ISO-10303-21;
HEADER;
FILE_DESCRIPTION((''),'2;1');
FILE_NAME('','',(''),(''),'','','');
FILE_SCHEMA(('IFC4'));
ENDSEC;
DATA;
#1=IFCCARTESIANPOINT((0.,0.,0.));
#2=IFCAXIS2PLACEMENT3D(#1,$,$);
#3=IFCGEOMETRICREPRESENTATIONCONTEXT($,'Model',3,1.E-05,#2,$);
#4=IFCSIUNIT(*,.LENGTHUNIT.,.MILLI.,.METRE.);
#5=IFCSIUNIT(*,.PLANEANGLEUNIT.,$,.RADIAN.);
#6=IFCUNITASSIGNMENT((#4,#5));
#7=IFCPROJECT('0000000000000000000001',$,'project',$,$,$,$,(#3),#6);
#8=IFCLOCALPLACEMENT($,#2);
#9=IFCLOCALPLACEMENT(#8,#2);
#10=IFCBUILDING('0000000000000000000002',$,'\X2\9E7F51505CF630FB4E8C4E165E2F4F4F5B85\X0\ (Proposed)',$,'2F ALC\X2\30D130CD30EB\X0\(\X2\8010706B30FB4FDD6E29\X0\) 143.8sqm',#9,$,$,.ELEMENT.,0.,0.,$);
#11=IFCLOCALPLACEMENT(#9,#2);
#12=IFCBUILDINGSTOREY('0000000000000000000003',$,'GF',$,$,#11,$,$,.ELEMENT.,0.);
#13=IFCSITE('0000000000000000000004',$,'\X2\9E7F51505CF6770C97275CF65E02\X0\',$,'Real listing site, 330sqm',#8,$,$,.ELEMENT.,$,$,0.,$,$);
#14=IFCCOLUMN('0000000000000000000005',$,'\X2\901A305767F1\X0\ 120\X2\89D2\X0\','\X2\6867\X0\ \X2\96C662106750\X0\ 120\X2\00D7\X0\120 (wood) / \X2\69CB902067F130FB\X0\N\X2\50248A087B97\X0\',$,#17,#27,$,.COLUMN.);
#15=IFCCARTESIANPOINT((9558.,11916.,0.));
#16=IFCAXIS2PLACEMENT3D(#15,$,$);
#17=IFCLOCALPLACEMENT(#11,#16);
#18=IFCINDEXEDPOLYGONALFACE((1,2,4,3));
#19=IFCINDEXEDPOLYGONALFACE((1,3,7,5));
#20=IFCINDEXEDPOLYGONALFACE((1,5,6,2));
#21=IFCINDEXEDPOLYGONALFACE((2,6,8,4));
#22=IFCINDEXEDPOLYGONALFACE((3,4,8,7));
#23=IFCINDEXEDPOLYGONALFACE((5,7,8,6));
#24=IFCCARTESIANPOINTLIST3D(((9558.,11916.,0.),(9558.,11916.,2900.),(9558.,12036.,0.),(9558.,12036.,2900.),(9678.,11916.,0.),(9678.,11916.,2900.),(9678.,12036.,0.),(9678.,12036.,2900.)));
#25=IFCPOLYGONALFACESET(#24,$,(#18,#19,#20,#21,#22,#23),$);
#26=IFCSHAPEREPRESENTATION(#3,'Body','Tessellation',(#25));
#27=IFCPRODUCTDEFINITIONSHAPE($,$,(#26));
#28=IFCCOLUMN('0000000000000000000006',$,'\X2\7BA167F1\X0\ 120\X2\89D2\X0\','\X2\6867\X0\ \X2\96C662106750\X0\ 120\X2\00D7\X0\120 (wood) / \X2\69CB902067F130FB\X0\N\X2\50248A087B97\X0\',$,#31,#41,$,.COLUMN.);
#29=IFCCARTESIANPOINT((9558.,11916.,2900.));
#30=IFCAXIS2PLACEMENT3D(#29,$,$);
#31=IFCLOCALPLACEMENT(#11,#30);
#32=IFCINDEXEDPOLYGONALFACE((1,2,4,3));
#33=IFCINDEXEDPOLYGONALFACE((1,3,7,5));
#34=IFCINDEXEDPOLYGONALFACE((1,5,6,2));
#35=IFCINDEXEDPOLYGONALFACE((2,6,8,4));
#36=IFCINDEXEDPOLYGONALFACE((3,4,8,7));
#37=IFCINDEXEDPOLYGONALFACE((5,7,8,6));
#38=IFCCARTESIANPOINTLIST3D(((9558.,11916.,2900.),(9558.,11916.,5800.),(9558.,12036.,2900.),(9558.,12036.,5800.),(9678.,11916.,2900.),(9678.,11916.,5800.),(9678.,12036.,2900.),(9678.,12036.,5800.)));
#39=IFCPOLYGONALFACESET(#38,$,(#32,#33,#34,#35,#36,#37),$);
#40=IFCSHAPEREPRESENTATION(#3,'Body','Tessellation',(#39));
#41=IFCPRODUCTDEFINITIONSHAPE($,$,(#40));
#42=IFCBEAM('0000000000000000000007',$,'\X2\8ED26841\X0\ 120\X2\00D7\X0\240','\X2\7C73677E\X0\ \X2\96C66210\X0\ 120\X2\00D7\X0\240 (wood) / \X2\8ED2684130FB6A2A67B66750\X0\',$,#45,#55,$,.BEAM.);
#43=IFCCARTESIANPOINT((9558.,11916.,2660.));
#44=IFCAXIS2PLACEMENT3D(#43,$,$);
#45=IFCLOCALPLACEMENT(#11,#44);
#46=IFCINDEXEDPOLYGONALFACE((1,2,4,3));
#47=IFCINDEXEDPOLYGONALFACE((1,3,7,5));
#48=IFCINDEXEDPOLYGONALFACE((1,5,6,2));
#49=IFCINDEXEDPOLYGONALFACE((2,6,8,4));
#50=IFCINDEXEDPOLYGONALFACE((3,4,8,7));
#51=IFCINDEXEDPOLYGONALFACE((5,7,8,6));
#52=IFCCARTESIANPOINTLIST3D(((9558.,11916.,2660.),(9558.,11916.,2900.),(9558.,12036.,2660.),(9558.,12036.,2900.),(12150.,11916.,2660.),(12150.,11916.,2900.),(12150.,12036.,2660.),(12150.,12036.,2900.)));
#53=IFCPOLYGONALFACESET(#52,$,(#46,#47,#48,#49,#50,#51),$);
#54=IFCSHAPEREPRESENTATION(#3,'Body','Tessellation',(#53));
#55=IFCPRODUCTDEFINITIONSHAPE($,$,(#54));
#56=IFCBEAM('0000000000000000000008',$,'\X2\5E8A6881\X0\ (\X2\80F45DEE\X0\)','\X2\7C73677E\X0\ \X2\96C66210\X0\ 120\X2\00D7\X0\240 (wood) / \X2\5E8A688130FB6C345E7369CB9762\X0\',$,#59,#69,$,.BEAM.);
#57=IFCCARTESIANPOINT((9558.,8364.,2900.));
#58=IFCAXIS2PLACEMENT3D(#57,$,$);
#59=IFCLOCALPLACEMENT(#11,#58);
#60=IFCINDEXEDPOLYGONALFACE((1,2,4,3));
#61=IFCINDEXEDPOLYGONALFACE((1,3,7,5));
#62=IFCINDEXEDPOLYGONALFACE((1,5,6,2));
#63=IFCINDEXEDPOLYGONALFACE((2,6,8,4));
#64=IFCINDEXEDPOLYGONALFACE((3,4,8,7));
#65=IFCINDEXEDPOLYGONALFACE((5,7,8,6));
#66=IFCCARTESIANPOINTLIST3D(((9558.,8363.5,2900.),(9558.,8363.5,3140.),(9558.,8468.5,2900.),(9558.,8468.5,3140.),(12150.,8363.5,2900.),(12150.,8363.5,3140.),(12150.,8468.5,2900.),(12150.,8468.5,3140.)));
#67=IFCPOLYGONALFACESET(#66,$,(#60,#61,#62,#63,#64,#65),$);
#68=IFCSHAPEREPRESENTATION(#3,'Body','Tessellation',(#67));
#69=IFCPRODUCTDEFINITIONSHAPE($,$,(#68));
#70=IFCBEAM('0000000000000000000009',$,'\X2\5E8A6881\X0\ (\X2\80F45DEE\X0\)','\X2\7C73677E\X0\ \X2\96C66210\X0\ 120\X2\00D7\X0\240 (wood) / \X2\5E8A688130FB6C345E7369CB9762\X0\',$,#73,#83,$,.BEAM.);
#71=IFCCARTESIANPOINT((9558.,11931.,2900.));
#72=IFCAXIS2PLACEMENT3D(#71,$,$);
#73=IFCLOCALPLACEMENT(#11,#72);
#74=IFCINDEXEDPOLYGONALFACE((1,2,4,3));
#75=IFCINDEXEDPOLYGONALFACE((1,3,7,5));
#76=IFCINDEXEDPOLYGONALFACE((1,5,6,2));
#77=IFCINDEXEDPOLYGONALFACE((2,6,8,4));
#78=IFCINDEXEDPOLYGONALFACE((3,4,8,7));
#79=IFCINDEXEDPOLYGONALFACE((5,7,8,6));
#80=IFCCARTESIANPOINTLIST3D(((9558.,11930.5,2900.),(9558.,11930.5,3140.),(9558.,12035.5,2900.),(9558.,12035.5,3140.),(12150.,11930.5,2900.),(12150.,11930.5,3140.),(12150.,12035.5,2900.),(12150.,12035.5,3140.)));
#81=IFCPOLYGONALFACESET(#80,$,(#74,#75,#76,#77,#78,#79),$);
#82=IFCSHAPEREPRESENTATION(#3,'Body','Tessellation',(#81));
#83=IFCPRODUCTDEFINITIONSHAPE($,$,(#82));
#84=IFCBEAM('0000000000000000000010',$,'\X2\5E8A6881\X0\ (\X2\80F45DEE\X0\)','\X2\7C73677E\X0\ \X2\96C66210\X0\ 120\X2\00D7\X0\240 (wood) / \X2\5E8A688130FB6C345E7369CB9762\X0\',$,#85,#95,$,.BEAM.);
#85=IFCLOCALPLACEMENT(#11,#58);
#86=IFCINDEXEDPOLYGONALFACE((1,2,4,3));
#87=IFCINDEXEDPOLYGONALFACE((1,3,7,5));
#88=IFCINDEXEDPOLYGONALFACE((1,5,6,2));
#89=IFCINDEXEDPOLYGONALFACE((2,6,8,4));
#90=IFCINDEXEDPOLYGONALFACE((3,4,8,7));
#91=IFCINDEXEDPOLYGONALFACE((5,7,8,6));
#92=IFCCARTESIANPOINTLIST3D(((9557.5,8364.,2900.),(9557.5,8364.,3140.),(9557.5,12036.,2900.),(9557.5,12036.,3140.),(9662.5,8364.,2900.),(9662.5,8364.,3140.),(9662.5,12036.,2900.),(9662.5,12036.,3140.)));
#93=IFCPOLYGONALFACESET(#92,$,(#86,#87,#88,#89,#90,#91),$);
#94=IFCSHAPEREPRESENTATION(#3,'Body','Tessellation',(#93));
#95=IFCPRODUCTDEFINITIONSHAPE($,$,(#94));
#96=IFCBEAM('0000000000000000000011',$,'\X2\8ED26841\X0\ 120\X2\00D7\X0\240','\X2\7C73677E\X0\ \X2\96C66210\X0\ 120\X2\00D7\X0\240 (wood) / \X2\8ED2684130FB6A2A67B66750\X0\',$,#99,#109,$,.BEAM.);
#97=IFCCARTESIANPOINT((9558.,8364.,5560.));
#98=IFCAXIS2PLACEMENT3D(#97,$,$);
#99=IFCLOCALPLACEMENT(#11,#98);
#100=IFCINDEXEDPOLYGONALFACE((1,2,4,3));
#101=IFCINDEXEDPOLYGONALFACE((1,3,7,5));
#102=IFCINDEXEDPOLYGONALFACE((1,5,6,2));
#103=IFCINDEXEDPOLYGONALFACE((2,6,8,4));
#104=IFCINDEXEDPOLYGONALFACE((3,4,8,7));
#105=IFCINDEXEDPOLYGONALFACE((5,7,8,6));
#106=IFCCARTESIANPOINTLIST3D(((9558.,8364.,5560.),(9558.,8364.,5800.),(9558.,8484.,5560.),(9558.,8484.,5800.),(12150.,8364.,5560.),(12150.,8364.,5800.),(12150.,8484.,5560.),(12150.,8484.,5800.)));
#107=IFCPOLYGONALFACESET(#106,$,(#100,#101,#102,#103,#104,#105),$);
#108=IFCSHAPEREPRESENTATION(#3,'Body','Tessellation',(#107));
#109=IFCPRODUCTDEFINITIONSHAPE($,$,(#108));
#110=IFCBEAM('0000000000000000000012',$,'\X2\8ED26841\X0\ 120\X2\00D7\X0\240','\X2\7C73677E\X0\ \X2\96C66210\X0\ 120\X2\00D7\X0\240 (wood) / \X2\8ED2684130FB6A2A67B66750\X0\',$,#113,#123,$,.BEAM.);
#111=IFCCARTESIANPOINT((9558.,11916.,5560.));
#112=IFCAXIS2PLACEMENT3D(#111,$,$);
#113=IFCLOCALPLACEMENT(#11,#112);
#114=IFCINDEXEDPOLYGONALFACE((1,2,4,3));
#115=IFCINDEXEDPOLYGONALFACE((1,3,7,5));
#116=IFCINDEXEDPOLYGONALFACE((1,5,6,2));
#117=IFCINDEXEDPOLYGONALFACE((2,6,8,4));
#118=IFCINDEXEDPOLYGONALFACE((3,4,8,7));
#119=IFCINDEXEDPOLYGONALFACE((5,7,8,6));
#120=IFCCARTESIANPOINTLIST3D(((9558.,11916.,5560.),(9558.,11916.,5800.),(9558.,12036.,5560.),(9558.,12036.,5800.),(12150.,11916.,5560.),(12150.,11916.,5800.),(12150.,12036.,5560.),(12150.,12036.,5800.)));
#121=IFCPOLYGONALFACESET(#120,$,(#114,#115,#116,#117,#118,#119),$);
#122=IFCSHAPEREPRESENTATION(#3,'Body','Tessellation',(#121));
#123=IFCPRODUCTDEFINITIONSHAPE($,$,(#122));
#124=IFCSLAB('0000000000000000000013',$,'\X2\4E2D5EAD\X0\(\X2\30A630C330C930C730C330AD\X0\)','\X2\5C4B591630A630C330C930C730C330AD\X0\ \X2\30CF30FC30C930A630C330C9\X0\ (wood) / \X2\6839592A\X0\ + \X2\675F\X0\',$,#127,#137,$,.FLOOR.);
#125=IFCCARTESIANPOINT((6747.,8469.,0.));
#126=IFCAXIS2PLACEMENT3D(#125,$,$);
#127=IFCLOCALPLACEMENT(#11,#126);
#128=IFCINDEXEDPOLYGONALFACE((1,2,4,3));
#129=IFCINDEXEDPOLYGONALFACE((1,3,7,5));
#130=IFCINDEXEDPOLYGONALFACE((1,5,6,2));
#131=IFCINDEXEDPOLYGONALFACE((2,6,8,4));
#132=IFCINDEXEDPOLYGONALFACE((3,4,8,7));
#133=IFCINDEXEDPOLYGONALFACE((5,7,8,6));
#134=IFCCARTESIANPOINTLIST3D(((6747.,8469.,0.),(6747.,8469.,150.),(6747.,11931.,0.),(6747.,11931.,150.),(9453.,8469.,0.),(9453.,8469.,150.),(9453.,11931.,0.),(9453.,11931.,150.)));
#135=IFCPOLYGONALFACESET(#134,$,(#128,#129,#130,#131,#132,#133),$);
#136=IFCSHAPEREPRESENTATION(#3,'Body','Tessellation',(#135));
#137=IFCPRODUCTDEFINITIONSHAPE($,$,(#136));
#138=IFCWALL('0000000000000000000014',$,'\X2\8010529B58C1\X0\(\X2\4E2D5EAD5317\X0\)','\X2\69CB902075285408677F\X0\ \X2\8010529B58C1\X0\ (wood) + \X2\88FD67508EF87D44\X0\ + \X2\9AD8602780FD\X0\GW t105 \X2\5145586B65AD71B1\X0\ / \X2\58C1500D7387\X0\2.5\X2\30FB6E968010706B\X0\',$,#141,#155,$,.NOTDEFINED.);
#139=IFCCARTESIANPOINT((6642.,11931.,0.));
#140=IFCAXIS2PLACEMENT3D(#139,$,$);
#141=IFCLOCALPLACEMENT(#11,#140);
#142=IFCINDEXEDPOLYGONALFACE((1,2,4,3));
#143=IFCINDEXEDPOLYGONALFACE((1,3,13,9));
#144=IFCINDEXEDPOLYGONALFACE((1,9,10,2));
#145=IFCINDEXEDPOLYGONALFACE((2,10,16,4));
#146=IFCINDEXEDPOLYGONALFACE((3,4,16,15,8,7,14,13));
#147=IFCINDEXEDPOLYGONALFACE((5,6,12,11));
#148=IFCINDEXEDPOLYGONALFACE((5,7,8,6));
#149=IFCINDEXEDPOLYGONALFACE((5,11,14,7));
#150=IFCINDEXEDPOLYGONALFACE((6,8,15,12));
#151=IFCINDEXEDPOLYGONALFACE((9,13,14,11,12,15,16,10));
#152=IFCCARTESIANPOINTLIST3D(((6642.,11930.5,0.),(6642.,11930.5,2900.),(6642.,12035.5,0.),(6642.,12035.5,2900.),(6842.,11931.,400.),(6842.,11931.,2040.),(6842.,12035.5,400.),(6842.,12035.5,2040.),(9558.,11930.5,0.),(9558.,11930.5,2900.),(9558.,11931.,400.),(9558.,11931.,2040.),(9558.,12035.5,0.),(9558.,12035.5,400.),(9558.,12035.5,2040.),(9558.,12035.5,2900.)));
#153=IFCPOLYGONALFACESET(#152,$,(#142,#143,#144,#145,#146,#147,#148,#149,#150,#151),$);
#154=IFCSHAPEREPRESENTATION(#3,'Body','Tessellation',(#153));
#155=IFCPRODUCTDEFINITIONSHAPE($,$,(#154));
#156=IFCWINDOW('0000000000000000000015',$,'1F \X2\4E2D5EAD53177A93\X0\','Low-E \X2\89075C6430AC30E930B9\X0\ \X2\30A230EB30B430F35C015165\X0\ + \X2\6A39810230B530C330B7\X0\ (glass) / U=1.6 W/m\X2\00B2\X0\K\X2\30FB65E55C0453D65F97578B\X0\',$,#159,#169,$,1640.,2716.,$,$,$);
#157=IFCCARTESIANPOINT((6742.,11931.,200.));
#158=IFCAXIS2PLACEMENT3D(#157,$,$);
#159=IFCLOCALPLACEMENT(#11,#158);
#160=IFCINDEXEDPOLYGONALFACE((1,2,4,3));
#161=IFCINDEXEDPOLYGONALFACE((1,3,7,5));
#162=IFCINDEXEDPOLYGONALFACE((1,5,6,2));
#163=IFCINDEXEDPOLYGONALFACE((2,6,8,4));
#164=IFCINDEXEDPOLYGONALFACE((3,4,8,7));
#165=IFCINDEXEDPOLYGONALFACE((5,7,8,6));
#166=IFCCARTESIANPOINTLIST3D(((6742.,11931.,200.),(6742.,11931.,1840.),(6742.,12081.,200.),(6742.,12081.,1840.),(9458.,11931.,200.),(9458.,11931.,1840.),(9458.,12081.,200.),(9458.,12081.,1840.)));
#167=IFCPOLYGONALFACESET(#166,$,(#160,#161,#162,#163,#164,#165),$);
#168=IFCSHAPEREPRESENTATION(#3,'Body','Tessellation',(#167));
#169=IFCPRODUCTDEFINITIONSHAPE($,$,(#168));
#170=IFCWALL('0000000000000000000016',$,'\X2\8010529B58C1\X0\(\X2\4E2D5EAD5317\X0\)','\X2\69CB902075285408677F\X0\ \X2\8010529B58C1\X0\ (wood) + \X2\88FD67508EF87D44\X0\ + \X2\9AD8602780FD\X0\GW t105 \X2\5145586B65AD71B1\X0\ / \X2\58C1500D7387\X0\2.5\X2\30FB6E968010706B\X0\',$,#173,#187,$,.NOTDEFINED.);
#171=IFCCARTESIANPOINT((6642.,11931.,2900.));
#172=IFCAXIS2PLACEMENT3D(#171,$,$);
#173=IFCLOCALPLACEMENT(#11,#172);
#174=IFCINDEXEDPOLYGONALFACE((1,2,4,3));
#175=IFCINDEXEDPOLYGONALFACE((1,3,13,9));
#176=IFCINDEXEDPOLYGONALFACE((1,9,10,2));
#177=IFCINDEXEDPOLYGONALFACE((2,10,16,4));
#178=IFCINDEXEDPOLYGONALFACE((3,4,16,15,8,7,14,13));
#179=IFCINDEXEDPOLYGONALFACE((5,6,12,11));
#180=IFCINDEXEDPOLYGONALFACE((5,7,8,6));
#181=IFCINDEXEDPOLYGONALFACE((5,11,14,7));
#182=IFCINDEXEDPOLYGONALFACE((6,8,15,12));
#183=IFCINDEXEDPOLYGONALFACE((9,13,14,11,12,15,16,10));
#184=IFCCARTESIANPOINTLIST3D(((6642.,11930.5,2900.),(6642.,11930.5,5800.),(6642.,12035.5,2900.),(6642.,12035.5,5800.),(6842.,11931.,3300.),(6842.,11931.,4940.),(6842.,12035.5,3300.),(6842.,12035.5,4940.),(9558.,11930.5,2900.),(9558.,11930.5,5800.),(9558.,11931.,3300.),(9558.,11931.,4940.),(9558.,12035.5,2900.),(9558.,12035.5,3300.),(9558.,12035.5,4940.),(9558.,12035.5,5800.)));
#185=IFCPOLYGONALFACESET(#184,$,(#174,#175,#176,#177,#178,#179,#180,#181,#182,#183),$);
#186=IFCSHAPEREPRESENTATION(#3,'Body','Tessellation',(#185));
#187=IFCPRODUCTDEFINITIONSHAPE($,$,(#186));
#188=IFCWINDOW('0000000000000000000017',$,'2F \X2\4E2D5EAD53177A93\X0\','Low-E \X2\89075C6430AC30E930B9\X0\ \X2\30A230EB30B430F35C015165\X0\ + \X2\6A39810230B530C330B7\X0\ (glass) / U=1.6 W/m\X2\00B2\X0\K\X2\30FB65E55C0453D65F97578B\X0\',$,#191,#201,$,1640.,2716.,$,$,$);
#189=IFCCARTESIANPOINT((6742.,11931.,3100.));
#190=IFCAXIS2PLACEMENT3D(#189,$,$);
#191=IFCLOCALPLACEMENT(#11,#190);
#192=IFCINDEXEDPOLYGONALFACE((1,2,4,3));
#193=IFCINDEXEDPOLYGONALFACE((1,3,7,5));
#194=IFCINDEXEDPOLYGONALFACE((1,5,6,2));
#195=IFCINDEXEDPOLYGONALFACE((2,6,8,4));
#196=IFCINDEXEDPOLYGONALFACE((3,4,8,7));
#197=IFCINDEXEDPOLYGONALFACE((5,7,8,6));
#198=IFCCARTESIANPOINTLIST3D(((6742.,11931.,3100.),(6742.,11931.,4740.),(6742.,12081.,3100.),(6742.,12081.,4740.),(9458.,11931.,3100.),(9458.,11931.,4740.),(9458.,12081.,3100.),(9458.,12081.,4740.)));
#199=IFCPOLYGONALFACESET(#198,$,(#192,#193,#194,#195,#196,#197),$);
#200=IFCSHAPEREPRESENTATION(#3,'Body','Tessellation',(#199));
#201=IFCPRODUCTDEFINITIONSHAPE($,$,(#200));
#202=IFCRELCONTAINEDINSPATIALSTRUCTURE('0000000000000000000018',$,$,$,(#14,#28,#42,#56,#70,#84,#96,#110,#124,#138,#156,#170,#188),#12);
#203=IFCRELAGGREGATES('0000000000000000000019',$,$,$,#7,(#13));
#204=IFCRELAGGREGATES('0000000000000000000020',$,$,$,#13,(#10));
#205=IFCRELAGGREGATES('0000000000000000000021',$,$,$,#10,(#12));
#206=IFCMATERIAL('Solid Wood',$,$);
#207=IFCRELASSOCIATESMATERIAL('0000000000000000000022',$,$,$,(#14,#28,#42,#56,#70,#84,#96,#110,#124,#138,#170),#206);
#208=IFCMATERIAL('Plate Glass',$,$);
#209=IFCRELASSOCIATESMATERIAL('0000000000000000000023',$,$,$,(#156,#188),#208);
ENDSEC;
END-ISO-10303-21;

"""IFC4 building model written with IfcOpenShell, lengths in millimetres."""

from ifc_helpers import new_model, si_unit, frame, frame_2d, origin, place, context, project, spatial, rectangle, extrude, material, element, fill, save


model = new_model("IFC4")

# Units and contexts
model_context = context("Model", 3, precision=1e-05, world=origin())
ifc_project = project(units=[si_unit("LENGTHUNIT", "METRE", prefix="MILLI"), si_unit("PLANEANGLEUNIT", "RADIAN")], contexts=[model_context])

# Site, building, storey
site_placement = place(None, origin())
site = spatial("IfcSite", under=ifc_project, at=site_placement, Name="鹿児島県霧島市", ObjectType="Real listing site, 330sqm", CompositionType="ELEMENT", RefElevation=0.0)
building_placement = place(site_placement, origin())
building = spatial("IfcBuilding", under=site, at=building_placement, Name="鹿児島・二世帯住宅 (Proposed)", ObjectType="2F ALCパネル(耐火・保温) 143.8sqm", CompositionType="ELEMENT", ElevationOfRefHeight=0.0, ElevationOfTerrain=0.0)
storey_placement = place(building_placement, origin())
storey = spatial("IfcBuildingStorey", under=building, at=storey_placement, Name="GF", CompositionType="ELEMENT", Elevation=0.0)

# Columns
ifc_material_1 = material(Name="Solid Wood")
column_1_placement = place(storey_placement, frame((9558.0, 11916.0, 0.0)))
element("IfcColumn", 1, at=column_1_placement, inside=storey, material=ifc_material_1, Name="通し柱 120角", Description="桧 集成材 120×120 (wood) / 構造柱・N値計算", PredefinedType="COLUMN", context=model_context, shape_type="SweptSolid", body=[
    extrude(rectangle(XDim=120.0, YDim=120.0, at=frame_2d((60.0, 60.0))), frame((9558.0, 11916.0, 0.0)), (0.0, 0.0, 1.0), 2900.0),
])
column_2_placement = place(storey_placement, frame((9558.0, 11916.0, 2900.0)))
element("IfcColumn", 2, at=column_2_placement, inside=storey, material=ifc_material_1, Name="管柱 120角", Description="桧 集成材 120×120 (wood) / 構造柱・N値計算", PredefinedType="COLUMN", context=model_context, shape_type="SweptSolid", body=[
    extrude(rectangle(XDim=120.0, YDim=120.0, at=frame_2d((60.0, 60.0))), frame((9558.0, 11916.0, 2900.0)), (0.0, 0.0, 1.0), 2900.0),
])

# Beams
beam_1_placement = place(storey_placement, frame((9558.0, 11916.0, 2660.0)))
element("IfcBeam", 3, at=beam_1_placement, inside=storey, material=ifc_material_1, Name="軒桁 120×240", Description="米松 集成 120×240 (wood) / 軒桁・横架材", PredefinedType="BEAM", context=model_context, shape_type="SweptSolid", body=[
    extrude(rectangle(XDim=2592.0, YDim=120.0, at=frame_2d((1296.0, 60.0))), frame((9558.0, 11916.0, 2660.0)), (0.0, 0.0, 1.0), 240.0),
])
beam_2_placement = place(storey_placement, frame((9558.0, 8364.0, 2900.0)))
element("IfcBeam", 4, at=beam_2_placement, inside=storey, material=ifc_material_1, Name="床梁 (胴差)", Description="米松 集成 120×240 (wood) / 床梁・水平構面", PredefinedType="BEAM", context=model_context, shape_type="SweptSolid", body=[
    extrude(rectangle(XDim=2592.0, YDim=105.0, at=frame_2d((1296.0, 52.0))), frame((9558.0, 8364.0, 2900.0)), (0.0, 0.0, 1.0), 240.0),
])
beam_3_placement = place(storey_placement, frame((9558.0, 11931.0, 2900.0)))
element("IfcBeam", 5, at=beam_3_placement, inside=storey, material=ifc_material_1, Name="床梁 (胴差)", Description="米松 集成 120×240 (wood) / 床梁・水平構面", PredefinedType="BEAM", context=model_context, shape_type="SweptSolid", body=[
    extrude(rectangle(XDim=2592.0, YDim=105.0, at=frame_2d((1296.0, 52.0))), frame((9558.0, 11931.0, 2900.0)), (0.0, 0.0, 1.0), 240.0),
])
beam_4_placement = place(storey_placement, frame((9558.0, 8364.0, 2900.0)))
element("IfcBeam", 6, at=beam_4_placement, inside=storey, material=ifc_material_1, Name="床梁 (胴差)", Description="米松 集成 120×240 (wood) / 床梁・水平構面", PredefinedType="BEAM", context=model_context, shape_type="SweptSolid", body=[
    extrude(rectangle(XDim=105.0, YDim=3672.0, at=frame_2d((52.0, 1836.0))), frame((9558.0, 8364.0, 2900.0)), (0.0, 0.0, 1.0), 240.0),
])
beam_5_placement = place(storey_placement, frame((9558.0, 8364.0, 5560.0)))
element("IfcBeam", 7, at=beam_5_placement, inside=storey, material=ifc_material_1, Name="軒桁 120×240", Description="米松 集成 120×240 (wood) / 軒桁・横架材", PredefinedType="BEAM", context=model_context, shape_type="SweptSolid", body=[
    extrude(rectangle(XDim=2592.0, YDim=120.0, at=frame_2d((1296.0, 60.0))), frame((9558.0, 8364.0, 5560.0)), (0.0, 0.0, 1.0), 240.0),
])
beam_6_placement = place(storey_placement, frame((9558.0, 11916.0, 5560.0)))
element("IfcBeam", 8, at=beam_6_placement, inside=storey, material=ifc_material_1, Name="軒桁 120×240", Description="米松 集成 120×240 (wood) / 軒桁・横架材", PredefinedType="BEAM", context=model_context, shape_type="SweptSolid", body=[
    extrude(rectangle(XDim=2592.0, YDim=120.0, at=frame_2d((1296.0, 60.0))), frame((9558.0, 11916.0, 5560.0)), (0.0, 0.0, 1.0), 240.0),
])

# Slab
slab_placement = place(storey_placement, frame((6747.0, 8469.0, 0.0)))
element("IfcSlab", 9, at=slab_placement, inside=storey, material=ifc_material_1, Name="中庭(ウッドデッキ)", Description="屋外ウッドデッキ ハードウッド (wood) / 根太 + 束", PredefinedType="FLOOR", context=model_context, shape_type="SweptSolid", body=[
    extrude(rectangle(XDim=2706.0, YDim=3462.0, at=frame_2d((1353.0, 1731.0))), frame((6747.0, 8469.0, 0.0)), (0.0, 0.0, 1.0), 150.0),
])

# Wall, opening, window
wall_1_placement = place(storey_placement, frame((6642.0, 11931.0, 0.0)))
wall_1 = element("IfcWall", 10, at=wall_1_placement, inside=storey, material=ifc_material_1, Name="耐力壁(中庭北)", Description="構造用合板 耐力壁 (wood) + 製材軸組 + 高性能GW t105 充填断熱 / 壁倍率2.5・準耐火", PredefinedType="NOTDEFINED", context=model_context, shape_type="SweptSolid", body=[
    extrude(rectangle(XDim=2916.0, YDim=105.0, at=frame_2d((1458.0, 52.0))), frame((6642.0, 11931.0, 0.0)), (0.0, 0.0, 1.0), 2900.0),
])
opening_1_placement = place(storey_placement, frame((6742.0, 11931.0, 200.0)))
opening_1 = element("IfcOpeningElement", 11, at=opening_1_placement, cuts=wall_1, PredefinedType="NOTDEFINED", context=model_context, shape_type="SweptSolid", body=[
    extrude(rectangle(XDim=2716.0, YDim=150.0, at=frame_2d((1358.0, 75.0))), frame((6742.0, 11931.0, 200.0)), (0.0, 0.0, 1.0), 1640.0),
])
ifc_material_2 = material(Name="Plate Glass")
window_1_placement = place(storey_placement, frame((6742.0, 11931.0, 200.0)))
window_1 = element("IfcWindow", 12, at=window_1_placement, inside=storey, material=ifc_material_2, Name="1F 中庭北窓", Description="Low-E 複層ガラス アルゴン封入 + 樹脂サッシ (glass) / U=1.6 W/m²K・日射取得型", OverallHeight=1640.0, OverallWidth=2716.0, context=model_context, shape_type="SweptSolid", body=[
    extrude(rectangle(XDim=2716.0, YDim=150.0, at=frame_2d((1358.0, 75.0))), frame((6742.0, 11931.0, 200.0)), (0.0, 0.0, 1.0), 1640.0),
])
fill(opening_1, window_1)

# Wall, opening, window
wall_2_placement = place(storey_placement, frame((6642.0, 11931.0, 2900.0)))
wall_2 = element("IfcWall", 13, at=wall_2_placement, inside=storey, material=ifc_material_1, Name="耐力壁(中庭北)", Description="構造用合板 耐力壁 (wood) + 製材軸組 + 高性能GW t105 充填断熱 / 壁倍率2.5・準耐火", PredefinedType="NOTDEFINED", context=model_context, shape_type="SweptSolid", body=[
    extrude(rectangle(XDim=2916.0, YDim=105.0, at=frame_2d((1458.0, 52.0))), frame((6642.0, 11931.0, 2900.0)), (0.0, 0.0, 1.0), 2900.0),
])
opening_2_placement = place(storey_placement, frame((6742.0, 11931.0, 3100.0)))
opening_2 = element("IfcOpeningElement", 14, at=opening_2_placement, cuts=wall_2, PredefinedType="NOTDEFINED", context=model_context, shape_type="SweptSolid", body=[
    extrude(rectangle(XDim=2716.0, YDim=150.0, at=frame_2d((1358.0, 75.0))), frame((6742.0, 11931.0, 3100.0)), (0.0, 0.0, 1.0), 1640.0),
])
window_2_placement = place(storey_placement, frame((6742.0, 11931.0, 3100.0)))
window_2 = element("IfcWindow", 15, at=window_2_placement, inside=storey, material=ifc_material_2, Name="2F 中庭北窓", Description="Low-E 複層ガラス アルゴン封入 + 樹脂サッシ (glass) / U=1.6 W/m²K・日射取得型", OverallHeight=1640.0, OverallWidth=2716.0, context=model_context, shape_type="SweptSolid", body=[
    extrude(rectangle(XDim=2716.0, YDim=150.0, at=frame_2d((1358.0, 75.0))), frame((6742.0, 11931.0, 3100.0)), (0.0, 0.0, 1.0), 1640.0),
])
fill(opening_2, window_2)

save(model, "model.ifc")
